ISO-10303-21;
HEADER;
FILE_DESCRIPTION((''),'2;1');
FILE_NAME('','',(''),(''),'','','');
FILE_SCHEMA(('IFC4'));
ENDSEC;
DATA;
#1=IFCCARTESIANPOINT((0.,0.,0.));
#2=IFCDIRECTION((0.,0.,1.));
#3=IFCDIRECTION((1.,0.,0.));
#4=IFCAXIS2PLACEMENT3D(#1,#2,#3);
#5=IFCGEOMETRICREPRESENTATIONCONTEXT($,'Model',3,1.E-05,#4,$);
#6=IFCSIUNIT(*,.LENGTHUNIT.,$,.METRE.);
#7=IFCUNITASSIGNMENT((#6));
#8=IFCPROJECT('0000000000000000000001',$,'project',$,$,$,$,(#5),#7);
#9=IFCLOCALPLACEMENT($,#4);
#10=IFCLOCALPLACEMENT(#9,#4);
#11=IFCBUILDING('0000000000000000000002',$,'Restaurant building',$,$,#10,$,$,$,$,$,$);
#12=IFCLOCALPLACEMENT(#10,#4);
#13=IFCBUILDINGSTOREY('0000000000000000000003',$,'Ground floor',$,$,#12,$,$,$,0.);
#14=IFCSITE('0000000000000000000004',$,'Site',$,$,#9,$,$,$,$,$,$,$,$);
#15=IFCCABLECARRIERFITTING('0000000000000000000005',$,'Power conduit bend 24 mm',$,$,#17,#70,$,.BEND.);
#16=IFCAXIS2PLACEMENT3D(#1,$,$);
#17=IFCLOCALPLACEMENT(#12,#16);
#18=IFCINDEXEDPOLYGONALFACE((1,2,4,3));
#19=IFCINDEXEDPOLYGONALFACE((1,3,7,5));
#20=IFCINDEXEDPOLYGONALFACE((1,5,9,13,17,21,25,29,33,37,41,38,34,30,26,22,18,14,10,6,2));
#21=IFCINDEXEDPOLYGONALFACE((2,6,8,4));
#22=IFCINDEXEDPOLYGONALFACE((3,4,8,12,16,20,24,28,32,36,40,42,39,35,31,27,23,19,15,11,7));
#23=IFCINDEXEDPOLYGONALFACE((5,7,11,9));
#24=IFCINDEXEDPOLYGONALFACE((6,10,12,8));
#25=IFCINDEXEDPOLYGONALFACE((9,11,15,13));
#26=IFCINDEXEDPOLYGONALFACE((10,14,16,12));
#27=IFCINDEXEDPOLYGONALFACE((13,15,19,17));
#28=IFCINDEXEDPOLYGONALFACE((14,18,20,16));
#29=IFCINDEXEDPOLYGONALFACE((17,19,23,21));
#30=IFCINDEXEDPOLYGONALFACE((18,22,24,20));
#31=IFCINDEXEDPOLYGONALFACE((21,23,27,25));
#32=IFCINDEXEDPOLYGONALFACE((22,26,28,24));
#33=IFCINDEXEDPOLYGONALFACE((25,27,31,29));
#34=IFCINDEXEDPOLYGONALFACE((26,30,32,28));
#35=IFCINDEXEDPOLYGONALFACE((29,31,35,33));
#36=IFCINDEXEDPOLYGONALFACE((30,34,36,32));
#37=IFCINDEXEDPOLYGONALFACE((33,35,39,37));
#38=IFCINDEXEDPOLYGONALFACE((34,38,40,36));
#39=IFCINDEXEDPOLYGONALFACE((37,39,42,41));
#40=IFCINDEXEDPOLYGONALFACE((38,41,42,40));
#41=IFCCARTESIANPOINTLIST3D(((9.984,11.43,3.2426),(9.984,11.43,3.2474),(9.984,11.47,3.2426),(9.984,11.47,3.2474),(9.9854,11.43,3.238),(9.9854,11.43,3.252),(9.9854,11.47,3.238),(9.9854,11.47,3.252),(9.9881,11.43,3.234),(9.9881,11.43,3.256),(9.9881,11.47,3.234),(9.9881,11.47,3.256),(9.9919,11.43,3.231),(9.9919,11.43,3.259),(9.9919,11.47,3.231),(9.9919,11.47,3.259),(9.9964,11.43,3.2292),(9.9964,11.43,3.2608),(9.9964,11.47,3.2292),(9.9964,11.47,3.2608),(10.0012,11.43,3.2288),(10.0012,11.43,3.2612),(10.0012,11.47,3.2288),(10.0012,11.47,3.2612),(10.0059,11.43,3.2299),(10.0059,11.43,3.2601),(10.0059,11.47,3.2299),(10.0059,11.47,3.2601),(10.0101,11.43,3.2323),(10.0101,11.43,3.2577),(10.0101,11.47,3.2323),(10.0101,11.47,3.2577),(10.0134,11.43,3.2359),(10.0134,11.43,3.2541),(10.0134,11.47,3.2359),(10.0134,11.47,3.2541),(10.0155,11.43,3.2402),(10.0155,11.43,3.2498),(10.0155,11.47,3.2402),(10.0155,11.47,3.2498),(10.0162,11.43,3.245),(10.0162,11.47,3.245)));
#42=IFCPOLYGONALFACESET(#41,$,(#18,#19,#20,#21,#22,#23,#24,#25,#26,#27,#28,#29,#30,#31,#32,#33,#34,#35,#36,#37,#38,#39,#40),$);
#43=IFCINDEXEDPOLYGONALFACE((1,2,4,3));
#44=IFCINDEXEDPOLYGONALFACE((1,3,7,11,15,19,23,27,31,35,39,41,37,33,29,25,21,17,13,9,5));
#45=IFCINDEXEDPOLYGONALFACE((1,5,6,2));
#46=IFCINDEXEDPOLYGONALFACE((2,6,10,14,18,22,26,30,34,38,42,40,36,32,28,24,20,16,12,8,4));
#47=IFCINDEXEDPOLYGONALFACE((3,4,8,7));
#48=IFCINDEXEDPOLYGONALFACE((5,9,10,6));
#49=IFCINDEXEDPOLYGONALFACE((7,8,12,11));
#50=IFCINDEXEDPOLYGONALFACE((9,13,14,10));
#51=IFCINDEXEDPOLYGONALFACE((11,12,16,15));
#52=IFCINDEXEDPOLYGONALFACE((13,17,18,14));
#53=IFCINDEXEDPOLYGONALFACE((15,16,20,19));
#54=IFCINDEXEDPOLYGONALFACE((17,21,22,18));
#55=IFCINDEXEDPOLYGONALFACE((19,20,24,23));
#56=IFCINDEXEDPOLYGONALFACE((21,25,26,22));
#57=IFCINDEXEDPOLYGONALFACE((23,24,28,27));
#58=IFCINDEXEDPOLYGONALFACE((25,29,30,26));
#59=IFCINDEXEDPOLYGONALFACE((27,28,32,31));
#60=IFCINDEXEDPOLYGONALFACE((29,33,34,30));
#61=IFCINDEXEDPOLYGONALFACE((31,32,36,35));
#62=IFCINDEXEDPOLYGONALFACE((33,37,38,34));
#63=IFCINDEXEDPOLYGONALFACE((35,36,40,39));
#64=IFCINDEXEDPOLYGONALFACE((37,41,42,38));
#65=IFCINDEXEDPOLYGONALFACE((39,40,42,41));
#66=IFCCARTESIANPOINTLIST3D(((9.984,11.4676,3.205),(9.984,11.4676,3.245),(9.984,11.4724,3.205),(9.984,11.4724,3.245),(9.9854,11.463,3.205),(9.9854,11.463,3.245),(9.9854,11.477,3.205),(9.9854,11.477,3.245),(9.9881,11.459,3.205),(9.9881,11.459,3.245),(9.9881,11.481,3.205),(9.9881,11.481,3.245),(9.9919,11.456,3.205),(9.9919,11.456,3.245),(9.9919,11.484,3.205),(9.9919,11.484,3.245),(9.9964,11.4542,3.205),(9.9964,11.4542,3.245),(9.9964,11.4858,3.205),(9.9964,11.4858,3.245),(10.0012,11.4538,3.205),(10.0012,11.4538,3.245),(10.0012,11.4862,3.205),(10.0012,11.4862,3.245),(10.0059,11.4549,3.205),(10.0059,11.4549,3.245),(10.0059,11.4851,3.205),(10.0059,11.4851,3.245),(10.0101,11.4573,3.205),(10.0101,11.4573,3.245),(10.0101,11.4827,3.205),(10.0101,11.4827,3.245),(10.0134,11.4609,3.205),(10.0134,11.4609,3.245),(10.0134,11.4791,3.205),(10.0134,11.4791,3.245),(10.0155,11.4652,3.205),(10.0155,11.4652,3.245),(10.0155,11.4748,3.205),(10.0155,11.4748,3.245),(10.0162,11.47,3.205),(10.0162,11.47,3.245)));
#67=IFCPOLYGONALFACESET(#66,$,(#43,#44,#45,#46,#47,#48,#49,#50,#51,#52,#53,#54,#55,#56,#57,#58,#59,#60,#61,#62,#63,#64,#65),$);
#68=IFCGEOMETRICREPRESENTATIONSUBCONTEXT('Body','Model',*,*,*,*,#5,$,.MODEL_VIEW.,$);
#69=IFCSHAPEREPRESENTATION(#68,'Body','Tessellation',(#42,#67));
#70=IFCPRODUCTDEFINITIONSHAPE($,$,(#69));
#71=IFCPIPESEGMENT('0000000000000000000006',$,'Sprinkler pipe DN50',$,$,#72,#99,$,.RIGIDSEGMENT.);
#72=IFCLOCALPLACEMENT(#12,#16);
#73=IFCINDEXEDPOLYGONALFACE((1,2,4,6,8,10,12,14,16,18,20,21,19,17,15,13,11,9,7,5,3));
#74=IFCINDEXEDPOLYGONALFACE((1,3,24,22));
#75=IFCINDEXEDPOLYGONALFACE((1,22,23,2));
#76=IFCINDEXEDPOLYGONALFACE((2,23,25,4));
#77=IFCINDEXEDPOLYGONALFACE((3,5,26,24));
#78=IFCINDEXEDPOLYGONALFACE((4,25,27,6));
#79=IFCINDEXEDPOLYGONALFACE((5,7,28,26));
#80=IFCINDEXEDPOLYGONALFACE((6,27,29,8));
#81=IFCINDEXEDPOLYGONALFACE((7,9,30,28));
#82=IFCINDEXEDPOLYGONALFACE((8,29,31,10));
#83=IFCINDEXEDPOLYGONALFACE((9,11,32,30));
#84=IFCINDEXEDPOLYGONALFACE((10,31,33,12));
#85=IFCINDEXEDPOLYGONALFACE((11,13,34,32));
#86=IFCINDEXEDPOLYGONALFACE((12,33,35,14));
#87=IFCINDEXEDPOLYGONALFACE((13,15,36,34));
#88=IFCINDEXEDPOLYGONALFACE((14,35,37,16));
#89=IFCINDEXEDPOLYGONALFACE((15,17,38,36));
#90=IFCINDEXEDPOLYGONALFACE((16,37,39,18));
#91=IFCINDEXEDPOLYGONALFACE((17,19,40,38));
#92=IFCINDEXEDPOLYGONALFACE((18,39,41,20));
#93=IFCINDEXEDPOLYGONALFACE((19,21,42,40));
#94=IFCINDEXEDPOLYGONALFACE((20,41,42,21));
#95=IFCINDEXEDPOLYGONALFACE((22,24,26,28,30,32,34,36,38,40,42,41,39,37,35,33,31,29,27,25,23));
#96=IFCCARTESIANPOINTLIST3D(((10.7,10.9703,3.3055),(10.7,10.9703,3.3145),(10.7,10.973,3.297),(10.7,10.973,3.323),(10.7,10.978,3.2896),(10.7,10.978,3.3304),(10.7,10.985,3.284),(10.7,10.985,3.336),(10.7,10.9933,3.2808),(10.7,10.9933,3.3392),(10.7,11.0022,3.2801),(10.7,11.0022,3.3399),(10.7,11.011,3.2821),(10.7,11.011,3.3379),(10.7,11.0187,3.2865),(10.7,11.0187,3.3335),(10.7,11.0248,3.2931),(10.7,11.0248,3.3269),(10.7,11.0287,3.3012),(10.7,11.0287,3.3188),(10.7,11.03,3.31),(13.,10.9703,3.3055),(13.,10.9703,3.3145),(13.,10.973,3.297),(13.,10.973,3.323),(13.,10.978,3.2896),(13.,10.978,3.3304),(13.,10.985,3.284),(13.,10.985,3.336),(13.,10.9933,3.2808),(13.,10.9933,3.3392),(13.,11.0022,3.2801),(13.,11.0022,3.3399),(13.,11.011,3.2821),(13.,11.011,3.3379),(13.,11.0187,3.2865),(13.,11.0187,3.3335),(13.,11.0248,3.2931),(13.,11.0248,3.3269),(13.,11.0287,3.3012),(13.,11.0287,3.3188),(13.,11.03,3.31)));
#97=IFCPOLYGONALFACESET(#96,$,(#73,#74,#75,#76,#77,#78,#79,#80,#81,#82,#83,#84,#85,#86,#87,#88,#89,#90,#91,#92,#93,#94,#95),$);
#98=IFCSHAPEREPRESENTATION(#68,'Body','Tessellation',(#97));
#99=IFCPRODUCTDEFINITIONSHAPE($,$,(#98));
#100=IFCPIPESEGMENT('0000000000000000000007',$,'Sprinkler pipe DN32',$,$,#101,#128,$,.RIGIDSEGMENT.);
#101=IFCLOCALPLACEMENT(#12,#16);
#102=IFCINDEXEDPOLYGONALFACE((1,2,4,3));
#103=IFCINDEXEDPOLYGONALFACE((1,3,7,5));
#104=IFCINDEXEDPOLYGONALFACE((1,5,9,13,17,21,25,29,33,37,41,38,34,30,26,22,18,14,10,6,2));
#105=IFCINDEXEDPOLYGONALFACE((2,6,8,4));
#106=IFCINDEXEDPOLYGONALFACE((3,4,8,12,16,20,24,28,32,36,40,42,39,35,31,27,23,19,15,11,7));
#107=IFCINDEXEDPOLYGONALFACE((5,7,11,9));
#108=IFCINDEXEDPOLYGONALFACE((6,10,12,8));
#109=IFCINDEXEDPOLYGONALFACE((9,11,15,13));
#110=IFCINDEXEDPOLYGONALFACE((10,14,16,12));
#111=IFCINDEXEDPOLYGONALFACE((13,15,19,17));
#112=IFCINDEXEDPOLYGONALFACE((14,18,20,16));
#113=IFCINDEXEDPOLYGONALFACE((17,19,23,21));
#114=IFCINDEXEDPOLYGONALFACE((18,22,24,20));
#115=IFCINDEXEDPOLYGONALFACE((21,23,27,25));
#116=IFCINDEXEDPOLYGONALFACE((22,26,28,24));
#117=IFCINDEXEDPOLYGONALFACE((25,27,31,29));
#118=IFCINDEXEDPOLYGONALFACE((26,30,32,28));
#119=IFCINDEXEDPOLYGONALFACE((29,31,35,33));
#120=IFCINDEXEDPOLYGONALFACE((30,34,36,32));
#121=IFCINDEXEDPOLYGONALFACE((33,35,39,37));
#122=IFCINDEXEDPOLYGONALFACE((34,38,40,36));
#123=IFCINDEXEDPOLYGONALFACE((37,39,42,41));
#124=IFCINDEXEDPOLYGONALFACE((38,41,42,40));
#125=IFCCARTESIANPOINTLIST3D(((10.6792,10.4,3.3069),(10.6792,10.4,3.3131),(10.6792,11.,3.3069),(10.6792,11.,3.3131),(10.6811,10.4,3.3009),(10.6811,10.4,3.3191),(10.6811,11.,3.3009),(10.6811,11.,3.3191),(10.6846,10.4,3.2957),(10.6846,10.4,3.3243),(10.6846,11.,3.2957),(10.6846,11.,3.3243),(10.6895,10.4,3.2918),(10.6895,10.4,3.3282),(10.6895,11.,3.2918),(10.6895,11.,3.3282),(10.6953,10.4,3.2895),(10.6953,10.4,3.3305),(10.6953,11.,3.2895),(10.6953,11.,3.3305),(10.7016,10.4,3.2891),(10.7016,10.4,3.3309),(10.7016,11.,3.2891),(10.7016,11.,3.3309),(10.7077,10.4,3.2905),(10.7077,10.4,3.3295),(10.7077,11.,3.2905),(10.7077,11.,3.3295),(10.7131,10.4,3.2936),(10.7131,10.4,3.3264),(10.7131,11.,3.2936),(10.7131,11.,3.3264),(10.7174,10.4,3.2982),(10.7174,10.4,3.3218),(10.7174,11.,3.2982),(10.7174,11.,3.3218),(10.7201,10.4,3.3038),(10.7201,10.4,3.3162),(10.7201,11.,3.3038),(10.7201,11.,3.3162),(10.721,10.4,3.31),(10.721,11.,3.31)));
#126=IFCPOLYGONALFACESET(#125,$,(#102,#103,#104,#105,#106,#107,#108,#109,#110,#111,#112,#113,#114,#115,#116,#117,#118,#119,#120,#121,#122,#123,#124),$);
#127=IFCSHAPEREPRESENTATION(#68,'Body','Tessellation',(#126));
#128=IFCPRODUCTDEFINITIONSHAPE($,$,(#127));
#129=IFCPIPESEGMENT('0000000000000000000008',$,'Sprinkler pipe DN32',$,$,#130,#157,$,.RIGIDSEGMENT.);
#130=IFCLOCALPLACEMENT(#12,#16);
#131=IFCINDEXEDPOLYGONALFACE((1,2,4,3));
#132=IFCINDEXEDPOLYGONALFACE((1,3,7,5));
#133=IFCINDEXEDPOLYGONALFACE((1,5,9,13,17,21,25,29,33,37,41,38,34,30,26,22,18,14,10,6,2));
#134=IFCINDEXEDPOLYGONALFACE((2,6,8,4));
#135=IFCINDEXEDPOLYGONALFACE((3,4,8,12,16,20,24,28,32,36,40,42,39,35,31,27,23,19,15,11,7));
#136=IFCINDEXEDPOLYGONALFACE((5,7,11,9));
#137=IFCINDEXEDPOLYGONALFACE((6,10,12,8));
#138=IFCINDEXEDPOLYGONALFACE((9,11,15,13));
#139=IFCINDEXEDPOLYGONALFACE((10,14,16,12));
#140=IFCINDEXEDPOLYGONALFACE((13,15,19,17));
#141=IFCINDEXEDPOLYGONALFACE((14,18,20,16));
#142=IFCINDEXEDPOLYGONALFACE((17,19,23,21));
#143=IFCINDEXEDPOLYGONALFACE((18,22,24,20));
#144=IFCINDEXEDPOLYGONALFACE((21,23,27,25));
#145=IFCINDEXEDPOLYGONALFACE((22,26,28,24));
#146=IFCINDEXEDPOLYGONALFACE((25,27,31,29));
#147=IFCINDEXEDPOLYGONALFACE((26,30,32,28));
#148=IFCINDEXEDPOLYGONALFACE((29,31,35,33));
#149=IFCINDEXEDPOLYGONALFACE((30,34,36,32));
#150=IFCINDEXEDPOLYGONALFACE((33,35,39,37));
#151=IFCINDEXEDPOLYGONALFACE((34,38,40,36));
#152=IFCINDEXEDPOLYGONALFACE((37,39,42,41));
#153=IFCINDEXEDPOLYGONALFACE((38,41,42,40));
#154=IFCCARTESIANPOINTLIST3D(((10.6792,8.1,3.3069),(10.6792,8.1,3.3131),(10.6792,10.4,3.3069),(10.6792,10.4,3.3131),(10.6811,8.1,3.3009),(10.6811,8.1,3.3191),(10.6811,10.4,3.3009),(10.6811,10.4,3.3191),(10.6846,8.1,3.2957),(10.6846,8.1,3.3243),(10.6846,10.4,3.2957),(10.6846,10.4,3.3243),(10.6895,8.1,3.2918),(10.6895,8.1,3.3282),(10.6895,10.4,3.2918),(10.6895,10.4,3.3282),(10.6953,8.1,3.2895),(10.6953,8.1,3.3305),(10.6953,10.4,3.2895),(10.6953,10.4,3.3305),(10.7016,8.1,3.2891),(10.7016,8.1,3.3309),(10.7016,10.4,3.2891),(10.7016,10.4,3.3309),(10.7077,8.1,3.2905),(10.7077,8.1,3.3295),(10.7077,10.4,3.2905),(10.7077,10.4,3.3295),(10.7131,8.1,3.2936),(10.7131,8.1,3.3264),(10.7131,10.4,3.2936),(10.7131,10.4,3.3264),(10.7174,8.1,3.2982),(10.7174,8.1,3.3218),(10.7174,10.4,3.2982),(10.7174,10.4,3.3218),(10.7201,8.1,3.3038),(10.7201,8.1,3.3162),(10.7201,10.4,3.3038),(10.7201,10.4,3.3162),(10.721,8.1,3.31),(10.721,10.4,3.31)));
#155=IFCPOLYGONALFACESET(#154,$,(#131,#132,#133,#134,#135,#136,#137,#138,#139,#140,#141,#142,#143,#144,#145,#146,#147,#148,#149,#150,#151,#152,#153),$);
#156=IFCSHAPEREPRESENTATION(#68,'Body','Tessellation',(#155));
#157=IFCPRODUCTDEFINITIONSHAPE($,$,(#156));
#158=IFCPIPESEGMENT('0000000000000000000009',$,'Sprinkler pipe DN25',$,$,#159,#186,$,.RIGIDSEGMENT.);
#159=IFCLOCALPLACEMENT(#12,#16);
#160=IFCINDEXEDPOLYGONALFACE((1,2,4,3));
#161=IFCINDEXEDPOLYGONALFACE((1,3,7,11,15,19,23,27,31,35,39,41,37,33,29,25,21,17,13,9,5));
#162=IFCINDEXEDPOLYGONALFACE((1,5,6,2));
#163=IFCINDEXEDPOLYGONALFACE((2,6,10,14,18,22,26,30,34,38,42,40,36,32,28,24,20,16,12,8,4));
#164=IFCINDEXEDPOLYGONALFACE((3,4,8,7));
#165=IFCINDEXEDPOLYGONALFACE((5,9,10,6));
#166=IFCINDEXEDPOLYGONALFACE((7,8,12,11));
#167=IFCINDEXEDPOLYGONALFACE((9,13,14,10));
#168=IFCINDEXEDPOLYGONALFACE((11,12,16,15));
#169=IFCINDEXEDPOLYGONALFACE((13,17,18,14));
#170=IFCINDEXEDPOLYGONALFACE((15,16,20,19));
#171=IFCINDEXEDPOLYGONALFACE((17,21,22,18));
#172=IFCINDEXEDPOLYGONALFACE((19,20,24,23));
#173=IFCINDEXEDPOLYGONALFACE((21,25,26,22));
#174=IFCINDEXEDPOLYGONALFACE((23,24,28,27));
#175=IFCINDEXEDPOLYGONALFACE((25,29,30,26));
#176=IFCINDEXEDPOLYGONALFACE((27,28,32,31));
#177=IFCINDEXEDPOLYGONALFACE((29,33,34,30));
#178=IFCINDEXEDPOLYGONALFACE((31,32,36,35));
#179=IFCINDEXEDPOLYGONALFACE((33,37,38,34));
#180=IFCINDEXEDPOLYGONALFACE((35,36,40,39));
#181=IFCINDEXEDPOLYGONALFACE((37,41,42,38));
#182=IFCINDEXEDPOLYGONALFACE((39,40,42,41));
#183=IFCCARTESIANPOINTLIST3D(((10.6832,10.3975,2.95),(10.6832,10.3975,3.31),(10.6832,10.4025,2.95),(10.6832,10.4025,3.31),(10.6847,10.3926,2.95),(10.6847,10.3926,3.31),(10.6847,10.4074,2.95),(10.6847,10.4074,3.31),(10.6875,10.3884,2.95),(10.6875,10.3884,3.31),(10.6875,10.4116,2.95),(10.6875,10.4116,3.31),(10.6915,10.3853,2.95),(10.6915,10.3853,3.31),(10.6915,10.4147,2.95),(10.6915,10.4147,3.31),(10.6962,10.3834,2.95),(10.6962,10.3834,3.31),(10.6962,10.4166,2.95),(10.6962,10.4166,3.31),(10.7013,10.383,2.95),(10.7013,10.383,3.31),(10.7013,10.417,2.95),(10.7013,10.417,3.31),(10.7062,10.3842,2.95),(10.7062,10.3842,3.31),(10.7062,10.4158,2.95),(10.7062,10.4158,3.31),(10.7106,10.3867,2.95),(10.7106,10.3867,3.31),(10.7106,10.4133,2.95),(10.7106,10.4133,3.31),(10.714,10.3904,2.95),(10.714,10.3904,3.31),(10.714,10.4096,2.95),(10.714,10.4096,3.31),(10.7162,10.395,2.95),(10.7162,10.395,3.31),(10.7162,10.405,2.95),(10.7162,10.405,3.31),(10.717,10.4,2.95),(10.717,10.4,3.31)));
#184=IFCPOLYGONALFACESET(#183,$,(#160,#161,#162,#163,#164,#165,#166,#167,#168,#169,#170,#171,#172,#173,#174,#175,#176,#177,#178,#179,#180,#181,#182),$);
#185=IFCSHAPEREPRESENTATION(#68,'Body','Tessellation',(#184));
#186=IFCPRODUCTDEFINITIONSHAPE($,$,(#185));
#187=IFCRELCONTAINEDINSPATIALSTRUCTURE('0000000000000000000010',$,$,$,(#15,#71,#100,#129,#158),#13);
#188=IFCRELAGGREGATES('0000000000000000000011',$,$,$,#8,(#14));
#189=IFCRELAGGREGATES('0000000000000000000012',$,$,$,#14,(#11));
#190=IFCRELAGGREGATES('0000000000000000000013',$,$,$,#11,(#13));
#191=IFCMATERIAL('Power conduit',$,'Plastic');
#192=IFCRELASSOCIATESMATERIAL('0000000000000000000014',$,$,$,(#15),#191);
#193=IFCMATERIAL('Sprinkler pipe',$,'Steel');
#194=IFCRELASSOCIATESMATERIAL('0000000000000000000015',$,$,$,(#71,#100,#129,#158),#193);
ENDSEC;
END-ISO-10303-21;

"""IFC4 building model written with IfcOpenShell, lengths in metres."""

from ifc_helpers import new_model, si_unit, frame, origin_with_axes, origin_2d, place, context, subcontext, project, spatial, circle, extrude, material, element, save


model = new_model("IFC4")

# Units and contexts
model_context = context("Model", 3, precision=1e-05, world=origin_with_axes())
body_context = subcontext(model_context, "Body", "Model", "MODEL_VIEW")
ifc_project = project(units=[si_unit("LENGTHUNIT", "METRE")], contexts=[model_context])

# Site, building, storey
site_placement = place(None, origin_with_axes())
site = spatial("IfcSite", under=ifc_project, at=site_placement, Name="Site")
building_placement = place(site_placement, origin_with_axes())
building = spatial("IfcBuilding", under=site, at=building_placement, Name="Restaurant building")
storey_placement = place(building_placement, origin_with_axes())
storey = spatial("IfcBuildingStorey", under=building, at=storey_placement, Name="Ground floor", Elevation=0.0)

# Shared definitions
ifc_material_1 = material(Name="Power conduit", Category="Plastic")

# Cable carrier fitting
cable_carrier_fitting_1_placement = place(storey_placement, frame((10.0, 11.47, 3.245)))
element("IfcCableCarrierFitting", 1, at=cable_carrier_fitting_1_placement, inside=storey, material=ifc_material_1, Name="Power conduit bend 24 mm", PredefinedType="BEND", context=body_context, shape_type="SweptSolid", body=[
    extrude(circle(Radius=0.0162, at=origin_2d()), frame((0.0, 0.0, 0.0), z_axis=(0.0, -1.0, 0.0), x_axis=(1.0, 0.0, 0.0)), (0.0, 0.0, 1.0), 0.04),
    extrude(circle(Radius=0.0162, at=origin_2d()), frame((0.0, 0.0, 0.0), z_axis=(0.0, 0.0, -1.0), x_axis=(1.0, 0.0, 0.0)), (0.0, 0.0, 1.0), 0.04),
])

# Pipe segments
ifc_material_2 = material(Name="Sprinkler pipe", Category="Steel")
pipe_segment_1_placement = place(storey_placement, frame((10.7, 11.0, 3.31)))
element("IfcPipeSegment", 2, at=pipe_segment_1_placement, inside=storey, material=ifc_material_2, Name="Sprinkler pipe DN50", PredefinedType="RIGIDSEGMENT", context=body_context, shape_type="SweptSolid", body=[
    extrude(circle(Radius=0.03, at=origin_2d()), frame((0.0, 0.0, 0.0), z_axis=(1.0, 0.0, 0.0), x_axis=(0.0, 1.0, 0.0)), (0.0, 0.0, 1.0), 2.3),
])
pipe_segment_2_placement = place(storey_placement, frame((10.7, 11.0, 3.31)))
element("IfcPipeSegment", 3, at=pipe_segment_2_placement, inside=storey, material=ifc_material_2, Name="Sprinkler pipe DN32", PredefinedType="RIGIDSEGMENT", context=body_context, shape_type="SweptSolid", body=[
    extrude(circle(Radius=0.021, at=origin_2d()), frame((0.0, 0.0, 0.0), z_axis=(0.0, -1.0, 0.0), x_axis=(1.0, 0.0, 0.0)), (0.0, 0.0, 1.0), 0.6),
])
pipe_segment_3_placement = place(storey_placement, frame((10.7, 10.4, 3.31)))
element("IfcPipeSegment", 4, at=pipe_segment_3_placement, inside=storey, material=ifc_material_2, Name="Sprinkler pipe DN32", PredefinedType="RIGIDSEGMENT", context=body_context, shape_type="SweptSolid", body=[
    extrude(circle(Radius=0.021, at=origin_2d()), frame((0.0, 0.0, 0.0), z_axis=(0.0, -1.0, 0.0), x_axis=(1.0, 0.0, 0.0)), (0.0, 0.0, 1.0), 2.3),
])
for number, where, name in (
    (5, (10.7, 10.4, 3.31), "Sprinkler pipe DN25"),
):
    element("IfcPipeSegment", number, at=place(storey_placement, frame(where)), inside=storey, material=ifc_material_2, Name=name, PredefinedType="RIGIDSEGMENT", context=body_context, shape_type="SweptSolid", body=[
        extrude(circle(Radius=0.017, at=origin_2d()), frame((0.0, 0.0, 0.0), z_axis=(0.0, 0.0, -1.0), x_axis=(1.0, 0.0, 0.0)), (0.0, 0.0, 1.0), 0.36),
    ])

save(model, "model.ifc")
